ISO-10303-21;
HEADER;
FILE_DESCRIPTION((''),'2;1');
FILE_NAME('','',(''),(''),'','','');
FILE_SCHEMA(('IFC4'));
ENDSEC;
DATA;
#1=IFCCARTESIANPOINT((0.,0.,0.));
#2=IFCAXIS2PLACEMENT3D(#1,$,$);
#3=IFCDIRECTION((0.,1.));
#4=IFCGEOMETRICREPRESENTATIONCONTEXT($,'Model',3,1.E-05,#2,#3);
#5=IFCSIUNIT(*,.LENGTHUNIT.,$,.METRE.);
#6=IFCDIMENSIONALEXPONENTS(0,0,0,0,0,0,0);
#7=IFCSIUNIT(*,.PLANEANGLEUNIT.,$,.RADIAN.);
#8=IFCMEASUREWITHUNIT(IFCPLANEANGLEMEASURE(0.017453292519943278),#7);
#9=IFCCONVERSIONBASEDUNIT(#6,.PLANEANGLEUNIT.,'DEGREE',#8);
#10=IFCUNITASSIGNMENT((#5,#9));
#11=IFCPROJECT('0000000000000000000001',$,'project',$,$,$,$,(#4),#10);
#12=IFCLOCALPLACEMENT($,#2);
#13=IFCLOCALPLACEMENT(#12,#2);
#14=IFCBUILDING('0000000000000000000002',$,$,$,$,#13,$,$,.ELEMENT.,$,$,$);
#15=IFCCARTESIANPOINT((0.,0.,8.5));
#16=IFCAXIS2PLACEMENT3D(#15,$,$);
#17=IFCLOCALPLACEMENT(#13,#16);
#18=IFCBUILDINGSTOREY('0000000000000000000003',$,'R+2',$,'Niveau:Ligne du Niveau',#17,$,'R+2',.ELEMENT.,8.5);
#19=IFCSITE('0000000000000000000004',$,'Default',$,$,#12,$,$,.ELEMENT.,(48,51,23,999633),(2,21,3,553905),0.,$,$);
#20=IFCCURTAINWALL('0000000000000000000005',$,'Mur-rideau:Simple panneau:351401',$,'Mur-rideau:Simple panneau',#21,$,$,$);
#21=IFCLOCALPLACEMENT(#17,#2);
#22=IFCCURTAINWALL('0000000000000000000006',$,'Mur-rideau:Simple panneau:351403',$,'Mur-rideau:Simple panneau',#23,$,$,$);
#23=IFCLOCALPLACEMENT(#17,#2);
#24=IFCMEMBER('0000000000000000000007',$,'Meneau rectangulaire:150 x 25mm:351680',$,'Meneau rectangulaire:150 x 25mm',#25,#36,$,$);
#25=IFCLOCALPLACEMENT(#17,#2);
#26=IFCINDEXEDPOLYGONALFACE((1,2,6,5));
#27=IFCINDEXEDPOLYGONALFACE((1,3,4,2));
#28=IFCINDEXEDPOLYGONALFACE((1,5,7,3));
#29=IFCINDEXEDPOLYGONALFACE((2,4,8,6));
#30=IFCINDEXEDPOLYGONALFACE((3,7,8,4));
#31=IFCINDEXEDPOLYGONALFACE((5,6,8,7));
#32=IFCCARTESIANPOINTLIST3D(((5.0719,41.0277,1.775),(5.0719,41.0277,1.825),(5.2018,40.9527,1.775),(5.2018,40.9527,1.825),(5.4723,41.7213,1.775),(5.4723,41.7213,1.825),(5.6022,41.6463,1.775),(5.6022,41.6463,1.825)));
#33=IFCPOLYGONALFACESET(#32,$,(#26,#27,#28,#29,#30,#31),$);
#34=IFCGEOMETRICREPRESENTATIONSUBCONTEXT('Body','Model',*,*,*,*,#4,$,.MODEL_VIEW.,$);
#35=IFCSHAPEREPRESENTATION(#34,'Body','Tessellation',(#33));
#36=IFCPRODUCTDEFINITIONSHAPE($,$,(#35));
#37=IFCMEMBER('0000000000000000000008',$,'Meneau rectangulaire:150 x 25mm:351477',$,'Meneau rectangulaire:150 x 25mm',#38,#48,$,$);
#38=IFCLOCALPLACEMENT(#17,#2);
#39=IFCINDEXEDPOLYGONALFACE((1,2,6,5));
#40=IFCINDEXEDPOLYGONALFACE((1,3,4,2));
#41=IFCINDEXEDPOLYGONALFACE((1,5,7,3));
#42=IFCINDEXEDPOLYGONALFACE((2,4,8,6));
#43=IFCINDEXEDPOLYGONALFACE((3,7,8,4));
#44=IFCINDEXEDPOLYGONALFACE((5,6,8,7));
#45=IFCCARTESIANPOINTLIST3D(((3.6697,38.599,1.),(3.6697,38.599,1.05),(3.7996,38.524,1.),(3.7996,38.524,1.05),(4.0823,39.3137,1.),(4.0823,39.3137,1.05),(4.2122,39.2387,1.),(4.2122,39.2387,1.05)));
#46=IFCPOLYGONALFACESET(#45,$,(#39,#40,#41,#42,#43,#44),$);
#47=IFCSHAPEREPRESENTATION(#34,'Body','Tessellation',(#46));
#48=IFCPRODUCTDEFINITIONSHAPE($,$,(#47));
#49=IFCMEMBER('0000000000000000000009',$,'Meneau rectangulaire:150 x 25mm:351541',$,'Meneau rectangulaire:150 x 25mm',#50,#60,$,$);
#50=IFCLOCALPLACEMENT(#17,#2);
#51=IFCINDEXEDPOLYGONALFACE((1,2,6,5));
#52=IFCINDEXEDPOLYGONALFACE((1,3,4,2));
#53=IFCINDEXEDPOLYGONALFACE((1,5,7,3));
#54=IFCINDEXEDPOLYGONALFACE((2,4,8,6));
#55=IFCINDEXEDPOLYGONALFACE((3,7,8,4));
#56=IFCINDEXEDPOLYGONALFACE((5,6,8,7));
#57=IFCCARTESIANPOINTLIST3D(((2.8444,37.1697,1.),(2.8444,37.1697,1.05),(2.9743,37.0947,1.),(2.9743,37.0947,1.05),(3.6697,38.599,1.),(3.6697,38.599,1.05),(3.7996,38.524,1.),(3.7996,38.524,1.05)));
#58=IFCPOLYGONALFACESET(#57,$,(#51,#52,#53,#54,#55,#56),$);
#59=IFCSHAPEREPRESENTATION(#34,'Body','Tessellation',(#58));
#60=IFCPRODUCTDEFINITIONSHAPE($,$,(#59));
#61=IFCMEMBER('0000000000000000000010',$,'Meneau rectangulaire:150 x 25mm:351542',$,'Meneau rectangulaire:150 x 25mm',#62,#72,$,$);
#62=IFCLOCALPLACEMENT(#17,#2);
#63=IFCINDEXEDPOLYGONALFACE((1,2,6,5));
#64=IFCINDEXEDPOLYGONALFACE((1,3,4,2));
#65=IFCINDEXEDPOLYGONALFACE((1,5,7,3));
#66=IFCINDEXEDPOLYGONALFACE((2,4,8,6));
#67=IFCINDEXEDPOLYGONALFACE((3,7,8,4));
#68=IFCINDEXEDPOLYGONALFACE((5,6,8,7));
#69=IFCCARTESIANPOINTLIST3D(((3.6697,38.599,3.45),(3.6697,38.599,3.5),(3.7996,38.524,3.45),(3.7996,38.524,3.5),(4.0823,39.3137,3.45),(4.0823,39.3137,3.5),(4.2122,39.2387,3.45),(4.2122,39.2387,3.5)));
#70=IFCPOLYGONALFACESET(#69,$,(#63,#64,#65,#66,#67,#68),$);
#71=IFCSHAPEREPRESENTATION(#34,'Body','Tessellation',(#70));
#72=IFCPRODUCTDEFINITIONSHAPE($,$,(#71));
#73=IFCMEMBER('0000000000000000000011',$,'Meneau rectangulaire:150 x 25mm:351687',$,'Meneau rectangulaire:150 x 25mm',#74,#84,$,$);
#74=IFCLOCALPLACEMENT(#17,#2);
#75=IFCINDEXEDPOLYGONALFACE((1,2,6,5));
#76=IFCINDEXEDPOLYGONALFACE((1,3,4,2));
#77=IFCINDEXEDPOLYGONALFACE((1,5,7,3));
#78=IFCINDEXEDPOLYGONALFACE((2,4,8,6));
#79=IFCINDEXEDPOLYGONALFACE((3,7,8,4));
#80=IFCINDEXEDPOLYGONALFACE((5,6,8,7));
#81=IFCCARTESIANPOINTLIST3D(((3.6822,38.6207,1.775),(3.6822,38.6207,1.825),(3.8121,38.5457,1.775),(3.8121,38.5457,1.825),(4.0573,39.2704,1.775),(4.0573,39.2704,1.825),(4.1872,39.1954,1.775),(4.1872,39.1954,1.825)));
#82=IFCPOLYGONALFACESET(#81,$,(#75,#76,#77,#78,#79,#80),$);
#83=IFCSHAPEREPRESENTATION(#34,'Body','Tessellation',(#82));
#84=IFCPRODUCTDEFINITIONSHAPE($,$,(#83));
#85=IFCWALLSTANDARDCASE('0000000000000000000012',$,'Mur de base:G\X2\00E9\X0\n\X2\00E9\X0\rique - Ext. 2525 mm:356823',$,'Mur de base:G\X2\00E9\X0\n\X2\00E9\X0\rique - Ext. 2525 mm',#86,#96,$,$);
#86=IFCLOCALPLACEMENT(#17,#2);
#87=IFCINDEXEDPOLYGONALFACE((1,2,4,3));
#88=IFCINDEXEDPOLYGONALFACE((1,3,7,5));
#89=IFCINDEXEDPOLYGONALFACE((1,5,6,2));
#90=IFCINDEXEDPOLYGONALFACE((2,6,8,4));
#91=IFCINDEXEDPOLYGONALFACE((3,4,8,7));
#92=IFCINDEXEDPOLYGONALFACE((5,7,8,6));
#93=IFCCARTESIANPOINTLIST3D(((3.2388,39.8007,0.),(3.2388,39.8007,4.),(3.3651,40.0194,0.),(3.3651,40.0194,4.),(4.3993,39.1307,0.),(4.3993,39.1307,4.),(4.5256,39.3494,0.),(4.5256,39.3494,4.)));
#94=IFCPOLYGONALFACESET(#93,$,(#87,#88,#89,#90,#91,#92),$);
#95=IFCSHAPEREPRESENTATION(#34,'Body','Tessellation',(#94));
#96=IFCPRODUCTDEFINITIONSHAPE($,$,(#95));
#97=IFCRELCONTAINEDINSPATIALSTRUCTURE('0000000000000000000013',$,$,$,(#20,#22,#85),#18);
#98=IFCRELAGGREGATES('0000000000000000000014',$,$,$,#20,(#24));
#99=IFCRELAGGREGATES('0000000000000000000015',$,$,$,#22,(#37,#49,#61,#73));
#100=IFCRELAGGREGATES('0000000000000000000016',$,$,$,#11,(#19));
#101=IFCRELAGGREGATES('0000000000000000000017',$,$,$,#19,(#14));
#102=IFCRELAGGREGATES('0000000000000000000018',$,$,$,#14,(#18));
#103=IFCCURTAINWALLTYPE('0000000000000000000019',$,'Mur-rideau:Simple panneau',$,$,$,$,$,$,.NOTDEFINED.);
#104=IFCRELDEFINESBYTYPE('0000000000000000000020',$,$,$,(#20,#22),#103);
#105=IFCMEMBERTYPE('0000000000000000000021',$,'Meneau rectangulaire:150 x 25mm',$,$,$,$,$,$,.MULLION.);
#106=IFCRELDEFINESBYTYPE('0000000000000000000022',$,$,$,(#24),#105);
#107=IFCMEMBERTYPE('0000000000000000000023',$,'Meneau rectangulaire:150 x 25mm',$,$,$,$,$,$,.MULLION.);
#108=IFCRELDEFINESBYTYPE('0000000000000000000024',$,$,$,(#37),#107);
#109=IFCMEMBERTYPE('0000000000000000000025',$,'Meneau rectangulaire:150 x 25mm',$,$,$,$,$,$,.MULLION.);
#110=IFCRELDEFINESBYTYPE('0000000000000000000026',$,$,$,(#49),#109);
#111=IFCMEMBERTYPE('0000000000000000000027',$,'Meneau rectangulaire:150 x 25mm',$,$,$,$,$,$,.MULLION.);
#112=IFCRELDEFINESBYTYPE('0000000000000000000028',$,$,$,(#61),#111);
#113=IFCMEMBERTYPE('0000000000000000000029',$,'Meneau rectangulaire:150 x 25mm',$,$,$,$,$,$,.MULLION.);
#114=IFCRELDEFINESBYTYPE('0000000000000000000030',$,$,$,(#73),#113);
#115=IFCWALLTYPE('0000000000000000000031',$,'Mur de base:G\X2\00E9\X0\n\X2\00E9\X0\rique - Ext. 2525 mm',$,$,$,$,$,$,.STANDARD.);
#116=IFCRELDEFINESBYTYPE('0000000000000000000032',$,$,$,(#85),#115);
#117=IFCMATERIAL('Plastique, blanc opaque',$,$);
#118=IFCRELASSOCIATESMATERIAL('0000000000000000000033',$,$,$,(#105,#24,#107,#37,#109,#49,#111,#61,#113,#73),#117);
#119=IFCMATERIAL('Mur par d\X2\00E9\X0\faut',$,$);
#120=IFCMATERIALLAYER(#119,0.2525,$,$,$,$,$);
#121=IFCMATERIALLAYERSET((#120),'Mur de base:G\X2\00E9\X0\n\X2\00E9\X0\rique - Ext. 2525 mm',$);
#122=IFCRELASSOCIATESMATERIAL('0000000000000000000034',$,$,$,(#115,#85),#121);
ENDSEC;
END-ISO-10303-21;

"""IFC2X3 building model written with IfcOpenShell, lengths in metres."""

from ifc_helpers import new_model, entity, si_unit, converted_unit, direction, frame, frame_2d, origin, origin_2d_with_axis, place, context, subcontext, project, spatial, rectangle, extrude, source, transform, mapped, material, layer, layer_set, layer_usage, type_object, type_shapes, element, aggregate, save


model = new_model("IFC2X3")

# Units and contexts
model_context = context("Model", 3, precision=1e-05, world=origin(), true_north=direction((0.0, 1.0)))
body_context = subcontext(model_context, "Body", "Model", "MODEL_VIEW")
ifc_project = project(units=[si_unit("LENGTHUNIT", "METRE"), converted_unit("PLANEANGLEUNIT", "DEGREE", entity("IfcPlaneAngleMeasure", 0.017453292519943278), si_unit("PLANEANGLEUNIT", "RADIAN"), dimensions=[0, 0, 0, 0, 0, 0, 0])], contexts=[model_context])

# Site, building, storey
site_placement = place(None, origin())
site = spatial("IfcSite", under=ifc_project, at=site_placement, Name="Default", CompositionType="ELEMENT", RefLatitude=(48, 51, 23, 999633), RefLongitude=(2, 21, 3, 553905), RefElevation=0.0)
building_placement = place(site_placement, origin())
building = spatial("IfcBuilding", under=site, at=building_placement, CompositionType="ELEMENT")
storey_placement = place(building_placement, frame((0.0, 0.0, 8.5)))
storey = spatial("IfcBuildingStorey", under=building, at=storey_placement, Name="R+2", ObjectType="Niveau:Ligne du Niveau", LongName="R+2", CompositionType="ELEMENT", Elevation=8.5)

# Curtain wall
curtain_wall_type = type_object("IfcCurtainWallType", Name="Mur-rideau:Simple panneau", PredefinedType="NOTDEFINED")
curtain_wall_1_placement = place(storey_placement, frame((0.0, 0.0, -8.5)))
curtain_wall_1 = element("IfcCurtainWall", 1, at=curtain_wall_1_placement, inside=storey, type_object=curtain_wall_type, Name="Mur-rideau:Simple panneau:351401", ObjectType="Mur-rideau:Simple panneau")
ifc_material_1 = material(Name="Plastique, blanc opaque")

# Curtain wall
curtain_wall_2_placement = place(storey_placement, frame((0.0, 0.0, -8.5)))
curtain_wall_2 = element("IfcCurtainWall", 2, at=curtain_wall_2_placement, inside=storey, type_object=curtain_wall_type, Name="Mur-rideau:Simple panneau:351403", ObjectType="Mur-rideau:Simple panneau")

# Members
member_type_1 = type_object("IfcMemberType", Name="Meneau rectangulaire:150 x 25mm", PredefinedType="MULLION", material=ifc_material_1)
shared_shape_1 = source(origin(), body_context, "Body", "SweptSolid", [
    extrude(rectangle(XDim=0.05, YDim=0.15, at=origin_2d_with_axis()), frame((0.0, 0.0, -0.8008), z_axis=(0.0, 0.0, 1.0), x_axis=(-1.0, 0.0, 0.0)), (0.0, 0.0, 1.0), 0.8008),
])
type_shapes(member_type_1, [shared_shape_1])
member_1_placement = place(curtain_wall_1_placement, frame((5.1369, 40.9902, 10.3), z_axis=(-0.5, -0.866025, 0.0), x_axis=(0.0, 0.0, 1.0)))
member_1 = element("IfcMember", 3, at=member_1_placement, type_object=member_type_1, material=ifc_material_1, Name="Meneau rectangulaire:150 x 25mm:351680", ObjectType="Meneau rectangulaire:150 x 25mm", context=body_context, shape_type="MappedRepresentation", body=[
    mapped(shared_shape_1, transform((0.0, 0.0, 0.0), scale=1.0)),
])
member_type_2 = type_object("IfcMemberType", Name="Meneau rectangulaire:150 x 25mm", PredefinedType="MULLION", material=ifc_material_1)
shared_shape_2 = source(origin(), body_context, "Body", "SweptSolid", [
    extrude(rectangle(XDim=0.05, YDim=0.15, at=origin_2d_with_axis()), frame((-0.025, 0.0, -0.8253), z_axis=(0.0, 0.0, 1.0), x_axis=(-1.0, 0.0, 0.0)), (0.0, 0.0, 1.0), 0.8253),
])
type_shapes(member_type_2, [shared_shape_2])
member_2_placement = place(curtain_wall_2_placement, frame((4.1473, 39.2762, 9.5), z_axis=(0.5, 0.866025, 0.0), x_axis=(0.0, 0.0, -1.0)))
member_2 = element("IfcMember", 4, at=member_2_placement, type_object=member_type_2, material=ifc_material_1, Name="Meneau rectangulaire:150 x 25mm:351477", ObjectType="Meneau rectangulaire:150 x 25mm", context=body_context, shape_type="MappedRepresentation", body=[
    mapped(shared_shape_2, transform((0.0, 0.0, 0.0), scale=1.0)),
])
member_type_3 = type_object("IfcMemberType", Name="Meneau rectangulaire:150 x 25mm", PredefinedType="MULLION", material=ifc_material_1)
shared_shape_3 = source(origin(), body_context, "Body", "SweptSolid", [
    extrude(rectangle(XDim=0.05, YDim=0.15, at=frame_2d((0.0, 0.0), x_axis=(1.0, 0.0))), frame((-0.025, 0.0, -1.6505), z_axis=(0.0, 0.0, 1.0), x_axis=(-1.0, 0.0, 0.0)), (0.0, 0.0, 1.0), 1.6505),
])
type_shapes(member_type_3, [shared_shape_3])
member_3_placement = place(curtain_wall_2_placement, frame((3.7347, 38.5615, 9.5), z_axis=(0.5, 0.866025, 0.0), x_axis=(0.0, 0.0, -1.0)))
member_3 = element("IfcMember", 5, at=member_3_placement, type_object=member_type_3, material=ifc_material_1, Name="Meneau rectangulaire:150 x 25mm:351541", ObjectType="Meneau rectangulaire:150 x 25mm", context=body_context, shape_type="MappedRepresentation", body=[
    mapped(shared_shape_3, transform((0.0, 0.0, 0.0), scale=1.0)),
])
member_type_4 = type_object("IfcMemberType", Name="Meneau rectangulaire:150 x 25mm", PredefinedType="MULLION", material=ifc_material_1)
shared_shape_4 = source(origin(), body_context, "Body", "SweptSolid", [
    extrude(rectangle(XDim=0.05, YDim=0.15, at=origin_2d_with_axis()), frame((-0.025, 0.0, -0.8253), z_axis=(0.0, 0.0, 1.0), x_axis=(-1.0, 0.0, 0.0)), (0.0, 0.0, 1.0), 0.8253),
])
type_shapes(member_type_4, [shared_shape_4])
member_4_placement = place(curtain_wall_2_placement, frame((3.7347, 38.5615, 12.0), z_axis=(-0.5, -0.866025, 0.0), x_axis=(0.0, 0.0, 1.0)))
member_4 = element("IfcMember", 6, at=member_4_placement, type_object=member_type_4, material=ifc_material_1, Name="Meneau rectangulaire:150 x 25mm:351542", ObjectType="Meneau rectangulaire:150 x 25mm", context=body_context, shape_type="MappedRepresentation", body=[
    mapped(shared_shape_4, transform((0.0, 0.0, 0.0), scale=1.0)),
])
member_type_5 = type_object("IfcMemberType", Name="Meneau rectangulaire:150 x 25mm", PredefinedType="MULLION", material=ifc_material_1)
shared_shape_5 = source(origin(), body_context, "Body", "SweptSolid", [
    extrude(rectangle(XDim=0.05, YDim=0.15, at=origin_2d_with_axis()), frame((0.0, 0.0, -0.7503), z_axis=(0.0, 0.0, 1.0), x_axis=(-1.0, 0.0, 0.0)), (0.0, 0.0, 1.0), 0.7503),
])
type_shapes(member_type_5, [shared_shape_5])
member_5_placement = place(curtain_wall_2_placement, frame((3.7472, 38.5832, 10.3), z_axis=(-0.5, -0.866025, 0.0), x_axis=(0.0, 0.0, 1.0)))
member_5 = element("IfcMember", 7, at=member_5_placement, type_object=member_type_5, material=ifc_material_1, Name="Meneau rectangulaire:150 x 25mm:351687", ObjectType="Meneau rectangulaire:150 x 25mm", context=body_context, shape_type="MappedRepresentation", body=[
    mapped(shared_shape_5, transform((0.0, 0.0, 0.0), scale=1.0)),
])

aggregate(curtain_wall_1, [member_1])
aggregate(curtain_wall_2, [member_2, member_3, member_4, member_5])

# Wall
ifc_material_2 = material(Name="Mur par défaut")
ifc_layer_1 = layer(ifc_material_2, 0.2525)
ifc_layer_set_1 = layer_set([ifc_layer_1], Name="Mur de base:Générique - Ext. 2525 mm")
ifc_layer_usage = layer_usage(ifc_layer_set_1, "AXIS2", "NEGATIVE", 0.1263)
wall_type = type_object("IfcWallType", Name="Mur de base:Générique - Ext. 2525 mm", PredefinedType="STANDARD", material=ifc_layer_set_1)
wall_placement = place(storey_placement, frame((4.4624, 39.2401, 0.0), z_axis=(0.0, 0.0, 1.0), x_axis=(-0.866025, 0.5, 0.0)))
element("IfcWallStandardCase", 8, at=wall_placement, inside=storey, type_object=wall_type, material=ifc_layer_usage, Name="Mur de base:Générique - Ext. 2525 mm:356823", ObjectType="Mur de base:Générique - Ext. 2525 mm", context=body_context, shape_type="SweptSolid", body=[
    extrude(rectangle(XDim=1.34, YDim=0.2525, at=frame_2d((0.67, 0.0), x_axis=(-1.0, 0.0))), origin(), (0.0, 0.0, 1.0), 4.0),
])

save(model, "model.ifc")
